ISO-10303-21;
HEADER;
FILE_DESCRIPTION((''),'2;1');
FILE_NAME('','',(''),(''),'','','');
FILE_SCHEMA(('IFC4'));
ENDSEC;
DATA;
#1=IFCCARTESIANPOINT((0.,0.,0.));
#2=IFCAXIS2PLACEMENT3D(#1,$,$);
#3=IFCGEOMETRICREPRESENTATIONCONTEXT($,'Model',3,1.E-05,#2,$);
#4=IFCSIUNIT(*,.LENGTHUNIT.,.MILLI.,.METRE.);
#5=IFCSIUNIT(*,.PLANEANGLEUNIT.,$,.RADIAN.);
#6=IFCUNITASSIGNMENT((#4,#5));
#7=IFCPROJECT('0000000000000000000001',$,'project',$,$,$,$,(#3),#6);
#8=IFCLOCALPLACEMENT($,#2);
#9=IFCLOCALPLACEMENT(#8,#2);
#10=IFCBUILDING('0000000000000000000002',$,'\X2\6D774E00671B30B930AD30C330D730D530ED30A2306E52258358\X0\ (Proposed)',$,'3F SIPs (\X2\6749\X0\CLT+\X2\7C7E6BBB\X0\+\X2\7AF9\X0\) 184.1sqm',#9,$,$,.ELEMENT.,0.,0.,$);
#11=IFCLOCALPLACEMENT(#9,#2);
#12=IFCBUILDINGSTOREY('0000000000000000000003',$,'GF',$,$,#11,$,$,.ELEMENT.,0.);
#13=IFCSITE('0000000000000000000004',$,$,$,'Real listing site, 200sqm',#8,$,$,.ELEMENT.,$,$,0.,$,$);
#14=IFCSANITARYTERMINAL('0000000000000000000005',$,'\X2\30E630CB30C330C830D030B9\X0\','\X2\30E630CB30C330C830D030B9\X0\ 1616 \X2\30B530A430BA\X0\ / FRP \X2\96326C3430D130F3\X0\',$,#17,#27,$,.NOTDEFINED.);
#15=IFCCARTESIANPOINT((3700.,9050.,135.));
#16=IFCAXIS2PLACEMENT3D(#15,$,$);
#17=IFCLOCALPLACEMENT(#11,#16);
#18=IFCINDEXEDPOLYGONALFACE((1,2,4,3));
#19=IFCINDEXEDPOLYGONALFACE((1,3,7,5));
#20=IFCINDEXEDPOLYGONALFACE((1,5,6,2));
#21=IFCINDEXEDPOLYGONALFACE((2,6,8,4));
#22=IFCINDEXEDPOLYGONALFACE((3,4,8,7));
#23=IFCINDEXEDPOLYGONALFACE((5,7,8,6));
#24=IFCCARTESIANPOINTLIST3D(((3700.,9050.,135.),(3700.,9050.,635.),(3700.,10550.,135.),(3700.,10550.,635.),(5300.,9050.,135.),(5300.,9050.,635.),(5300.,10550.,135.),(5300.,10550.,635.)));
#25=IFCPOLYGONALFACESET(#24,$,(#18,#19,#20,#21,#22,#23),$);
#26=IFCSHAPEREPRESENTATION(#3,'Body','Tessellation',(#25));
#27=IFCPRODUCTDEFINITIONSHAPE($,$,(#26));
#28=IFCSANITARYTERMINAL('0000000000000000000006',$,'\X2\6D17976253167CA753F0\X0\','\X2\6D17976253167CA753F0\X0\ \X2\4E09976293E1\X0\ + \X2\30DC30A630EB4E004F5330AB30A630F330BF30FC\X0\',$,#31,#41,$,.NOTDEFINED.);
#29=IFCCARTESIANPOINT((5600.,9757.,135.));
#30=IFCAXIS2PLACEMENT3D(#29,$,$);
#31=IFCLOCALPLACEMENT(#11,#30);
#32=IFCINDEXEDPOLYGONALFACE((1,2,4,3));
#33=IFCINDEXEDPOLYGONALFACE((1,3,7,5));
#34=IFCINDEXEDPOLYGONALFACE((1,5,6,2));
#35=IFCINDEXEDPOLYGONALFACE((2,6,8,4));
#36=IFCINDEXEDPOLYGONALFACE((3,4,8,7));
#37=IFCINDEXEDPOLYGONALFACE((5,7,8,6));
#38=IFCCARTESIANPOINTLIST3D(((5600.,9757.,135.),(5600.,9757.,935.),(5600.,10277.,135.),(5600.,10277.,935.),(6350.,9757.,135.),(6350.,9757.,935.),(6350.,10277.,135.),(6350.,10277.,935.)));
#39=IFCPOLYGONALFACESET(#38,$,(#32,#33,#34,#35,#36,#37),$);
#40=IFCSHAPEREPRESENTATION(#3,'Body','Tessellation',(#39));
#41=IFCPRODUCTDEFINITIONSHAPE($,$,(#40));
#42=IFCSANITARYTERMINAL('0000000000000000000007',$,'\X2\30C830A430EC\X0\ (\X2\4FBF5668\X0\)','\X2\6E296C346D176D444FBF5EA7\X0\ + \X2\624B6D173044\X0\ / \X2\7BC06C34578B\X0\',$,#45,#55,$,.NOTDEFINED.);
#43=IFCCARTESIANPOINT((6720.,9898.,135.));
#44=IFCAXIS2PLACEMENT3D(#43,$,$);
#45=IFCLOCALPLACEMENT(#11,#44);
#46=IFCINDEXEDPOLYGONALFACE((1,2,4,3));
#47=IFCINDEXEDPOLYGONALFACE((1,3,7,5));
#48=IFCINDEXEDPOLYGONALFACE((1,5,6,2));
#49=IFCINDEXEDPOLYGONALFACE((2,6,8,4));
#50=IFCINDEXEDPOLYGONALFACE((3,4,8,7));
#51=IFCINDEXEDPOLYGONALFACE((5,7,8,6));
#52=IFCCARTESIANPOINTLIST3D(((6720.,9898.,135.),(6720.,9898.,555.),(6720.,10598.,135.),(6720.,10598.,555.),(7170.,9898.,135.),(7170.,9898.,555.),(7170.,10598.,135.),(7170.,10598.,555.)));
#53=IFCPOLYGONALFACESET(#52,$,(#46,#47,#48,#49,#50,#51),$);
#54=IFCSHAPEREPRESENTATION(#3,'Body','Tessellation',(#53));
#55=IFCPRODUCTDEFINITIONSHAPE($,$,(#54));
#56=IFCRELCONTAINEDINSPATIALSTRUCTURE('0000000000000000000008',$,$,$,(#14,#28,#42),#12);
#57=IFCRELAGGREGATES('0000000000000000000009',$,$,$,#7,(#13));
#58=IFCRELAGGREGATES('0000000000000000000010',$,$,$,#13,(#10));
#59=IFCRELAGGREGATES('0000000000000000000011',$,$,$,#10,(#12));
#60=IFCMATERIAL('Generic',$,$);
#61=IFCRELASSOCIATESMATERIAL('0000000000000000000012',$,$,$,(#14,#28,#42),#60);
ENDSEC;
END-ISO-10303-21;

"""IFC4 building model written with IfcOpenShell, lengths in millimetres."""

from ifc_helpers import new_model, si_unit, frame, frame_2d, origin, place, context, project, spatial, rectangle, extrude, material, element, save


model = new_model("IFC4")

# Units and contexts
model_context = context("Model", 3, precision=1e-05, world=origin())
ifc_project = project(units=[si_unit("LENGTHUNIT", "METRE", prefix="MILLI"), si_unit("PLANEANGLEUNIT", "RADIAN")], contexts=[model_context])

# Site, building, storey
site_placement = place(None, origin())
site = spatial("IfcSite", under=ifc_project, at=site_placement, ObjectType="Real listing site, 200sqm", CompositionType="ELEMENT", RefElevation=0.0)
building_placement = place(site_placement, origin())
building = spatial("IfcBuilding", under=site, at=building_placement, Name="海一望スキップフロアの別荘 (Proposed)", ObjectType="3F SIPs (杉CLT+籾殻+竹) 184.1sqm", CompositionType="ELEMENT", ElevationOfRefHeight=0.0, ElevationOfTerrain=0.0)
storey_placement = place(building_placement, origin())
storey = spatial("IfcBuildingStorey", under=building, at=storey_placement, Name="GF", CompositionType="ELEMENT", Elevation=0.0)

# Shared definitions
ifc_material_1 = material(Name="Generic")

# Sanitary terminals
sanitary_terminal_1_placement = place(storey_placement, frame((3700.0, 9050.0, 135.0)))
element("IfcSanitaryTerminal", 1, at=sanitary_terminal_1_placement, inside=storey, material=ifc_material_1, Name="ユニットバス", Description="ユニットバス 1616 サイズ / FRP 防水パン", PredefinedType="NOTDEFINED", context=model_context, shape_type="SweptSolid", body=[
    extrude(rectangle(XDim=1600.0, YDim=1500.0, at=frame_2d((800.0, 750.0))), frame((3700.0, 9050.0, 135.0)), (0.0, 0.0, 1.0), 500.0),
])
sanitary_terminal_2_placement = place(storey_placement, frame((5600.0, 9757.0, 135.0)))
element("IfcSanitaryTerminal", 2, at=sanitary_terminal_2_placement, inside=storey, material=ifc_material_1, Name="洗面化粧台", Description="洗面化粧台 三面鏡 + ボウル一体カウンター", PredefinedType="NOTDEFINED", context=model_context, shape_type="SweptSolid", body=[
    extrude(rectangle(XDim=750.0, YDim=520.0, at=frame_2d((375.0, 260.0))), frame((5600.0, 9757.0, 135.0)), (0.0, 0.0, 1.0), 800.0),
])
sanitary_terminal_3_placement = place(storey_placement, frame((6720.0, 9898.0, 135.0)))
element("IfcSanitaryTerminal", 3, at=sanitary_terminal_3_placement, inside=storey, material=ifc_material_1, Name="トイレ (便器)", Description="温水洗浄便座 + 手洗い / 節水型", PredefinedType="NOTDEFINED", context=model_context, shape_type="SweptSolid", body=[
    extrude(rectangle(XDim=450.0, YDim=700.0, at=frame_2d((225.0, 350.0))), frame((6720.0, 9898.0, 135.0)), (0.0, 0.0, 1.0), 420.0),
])

save(model, "model.ifc")
